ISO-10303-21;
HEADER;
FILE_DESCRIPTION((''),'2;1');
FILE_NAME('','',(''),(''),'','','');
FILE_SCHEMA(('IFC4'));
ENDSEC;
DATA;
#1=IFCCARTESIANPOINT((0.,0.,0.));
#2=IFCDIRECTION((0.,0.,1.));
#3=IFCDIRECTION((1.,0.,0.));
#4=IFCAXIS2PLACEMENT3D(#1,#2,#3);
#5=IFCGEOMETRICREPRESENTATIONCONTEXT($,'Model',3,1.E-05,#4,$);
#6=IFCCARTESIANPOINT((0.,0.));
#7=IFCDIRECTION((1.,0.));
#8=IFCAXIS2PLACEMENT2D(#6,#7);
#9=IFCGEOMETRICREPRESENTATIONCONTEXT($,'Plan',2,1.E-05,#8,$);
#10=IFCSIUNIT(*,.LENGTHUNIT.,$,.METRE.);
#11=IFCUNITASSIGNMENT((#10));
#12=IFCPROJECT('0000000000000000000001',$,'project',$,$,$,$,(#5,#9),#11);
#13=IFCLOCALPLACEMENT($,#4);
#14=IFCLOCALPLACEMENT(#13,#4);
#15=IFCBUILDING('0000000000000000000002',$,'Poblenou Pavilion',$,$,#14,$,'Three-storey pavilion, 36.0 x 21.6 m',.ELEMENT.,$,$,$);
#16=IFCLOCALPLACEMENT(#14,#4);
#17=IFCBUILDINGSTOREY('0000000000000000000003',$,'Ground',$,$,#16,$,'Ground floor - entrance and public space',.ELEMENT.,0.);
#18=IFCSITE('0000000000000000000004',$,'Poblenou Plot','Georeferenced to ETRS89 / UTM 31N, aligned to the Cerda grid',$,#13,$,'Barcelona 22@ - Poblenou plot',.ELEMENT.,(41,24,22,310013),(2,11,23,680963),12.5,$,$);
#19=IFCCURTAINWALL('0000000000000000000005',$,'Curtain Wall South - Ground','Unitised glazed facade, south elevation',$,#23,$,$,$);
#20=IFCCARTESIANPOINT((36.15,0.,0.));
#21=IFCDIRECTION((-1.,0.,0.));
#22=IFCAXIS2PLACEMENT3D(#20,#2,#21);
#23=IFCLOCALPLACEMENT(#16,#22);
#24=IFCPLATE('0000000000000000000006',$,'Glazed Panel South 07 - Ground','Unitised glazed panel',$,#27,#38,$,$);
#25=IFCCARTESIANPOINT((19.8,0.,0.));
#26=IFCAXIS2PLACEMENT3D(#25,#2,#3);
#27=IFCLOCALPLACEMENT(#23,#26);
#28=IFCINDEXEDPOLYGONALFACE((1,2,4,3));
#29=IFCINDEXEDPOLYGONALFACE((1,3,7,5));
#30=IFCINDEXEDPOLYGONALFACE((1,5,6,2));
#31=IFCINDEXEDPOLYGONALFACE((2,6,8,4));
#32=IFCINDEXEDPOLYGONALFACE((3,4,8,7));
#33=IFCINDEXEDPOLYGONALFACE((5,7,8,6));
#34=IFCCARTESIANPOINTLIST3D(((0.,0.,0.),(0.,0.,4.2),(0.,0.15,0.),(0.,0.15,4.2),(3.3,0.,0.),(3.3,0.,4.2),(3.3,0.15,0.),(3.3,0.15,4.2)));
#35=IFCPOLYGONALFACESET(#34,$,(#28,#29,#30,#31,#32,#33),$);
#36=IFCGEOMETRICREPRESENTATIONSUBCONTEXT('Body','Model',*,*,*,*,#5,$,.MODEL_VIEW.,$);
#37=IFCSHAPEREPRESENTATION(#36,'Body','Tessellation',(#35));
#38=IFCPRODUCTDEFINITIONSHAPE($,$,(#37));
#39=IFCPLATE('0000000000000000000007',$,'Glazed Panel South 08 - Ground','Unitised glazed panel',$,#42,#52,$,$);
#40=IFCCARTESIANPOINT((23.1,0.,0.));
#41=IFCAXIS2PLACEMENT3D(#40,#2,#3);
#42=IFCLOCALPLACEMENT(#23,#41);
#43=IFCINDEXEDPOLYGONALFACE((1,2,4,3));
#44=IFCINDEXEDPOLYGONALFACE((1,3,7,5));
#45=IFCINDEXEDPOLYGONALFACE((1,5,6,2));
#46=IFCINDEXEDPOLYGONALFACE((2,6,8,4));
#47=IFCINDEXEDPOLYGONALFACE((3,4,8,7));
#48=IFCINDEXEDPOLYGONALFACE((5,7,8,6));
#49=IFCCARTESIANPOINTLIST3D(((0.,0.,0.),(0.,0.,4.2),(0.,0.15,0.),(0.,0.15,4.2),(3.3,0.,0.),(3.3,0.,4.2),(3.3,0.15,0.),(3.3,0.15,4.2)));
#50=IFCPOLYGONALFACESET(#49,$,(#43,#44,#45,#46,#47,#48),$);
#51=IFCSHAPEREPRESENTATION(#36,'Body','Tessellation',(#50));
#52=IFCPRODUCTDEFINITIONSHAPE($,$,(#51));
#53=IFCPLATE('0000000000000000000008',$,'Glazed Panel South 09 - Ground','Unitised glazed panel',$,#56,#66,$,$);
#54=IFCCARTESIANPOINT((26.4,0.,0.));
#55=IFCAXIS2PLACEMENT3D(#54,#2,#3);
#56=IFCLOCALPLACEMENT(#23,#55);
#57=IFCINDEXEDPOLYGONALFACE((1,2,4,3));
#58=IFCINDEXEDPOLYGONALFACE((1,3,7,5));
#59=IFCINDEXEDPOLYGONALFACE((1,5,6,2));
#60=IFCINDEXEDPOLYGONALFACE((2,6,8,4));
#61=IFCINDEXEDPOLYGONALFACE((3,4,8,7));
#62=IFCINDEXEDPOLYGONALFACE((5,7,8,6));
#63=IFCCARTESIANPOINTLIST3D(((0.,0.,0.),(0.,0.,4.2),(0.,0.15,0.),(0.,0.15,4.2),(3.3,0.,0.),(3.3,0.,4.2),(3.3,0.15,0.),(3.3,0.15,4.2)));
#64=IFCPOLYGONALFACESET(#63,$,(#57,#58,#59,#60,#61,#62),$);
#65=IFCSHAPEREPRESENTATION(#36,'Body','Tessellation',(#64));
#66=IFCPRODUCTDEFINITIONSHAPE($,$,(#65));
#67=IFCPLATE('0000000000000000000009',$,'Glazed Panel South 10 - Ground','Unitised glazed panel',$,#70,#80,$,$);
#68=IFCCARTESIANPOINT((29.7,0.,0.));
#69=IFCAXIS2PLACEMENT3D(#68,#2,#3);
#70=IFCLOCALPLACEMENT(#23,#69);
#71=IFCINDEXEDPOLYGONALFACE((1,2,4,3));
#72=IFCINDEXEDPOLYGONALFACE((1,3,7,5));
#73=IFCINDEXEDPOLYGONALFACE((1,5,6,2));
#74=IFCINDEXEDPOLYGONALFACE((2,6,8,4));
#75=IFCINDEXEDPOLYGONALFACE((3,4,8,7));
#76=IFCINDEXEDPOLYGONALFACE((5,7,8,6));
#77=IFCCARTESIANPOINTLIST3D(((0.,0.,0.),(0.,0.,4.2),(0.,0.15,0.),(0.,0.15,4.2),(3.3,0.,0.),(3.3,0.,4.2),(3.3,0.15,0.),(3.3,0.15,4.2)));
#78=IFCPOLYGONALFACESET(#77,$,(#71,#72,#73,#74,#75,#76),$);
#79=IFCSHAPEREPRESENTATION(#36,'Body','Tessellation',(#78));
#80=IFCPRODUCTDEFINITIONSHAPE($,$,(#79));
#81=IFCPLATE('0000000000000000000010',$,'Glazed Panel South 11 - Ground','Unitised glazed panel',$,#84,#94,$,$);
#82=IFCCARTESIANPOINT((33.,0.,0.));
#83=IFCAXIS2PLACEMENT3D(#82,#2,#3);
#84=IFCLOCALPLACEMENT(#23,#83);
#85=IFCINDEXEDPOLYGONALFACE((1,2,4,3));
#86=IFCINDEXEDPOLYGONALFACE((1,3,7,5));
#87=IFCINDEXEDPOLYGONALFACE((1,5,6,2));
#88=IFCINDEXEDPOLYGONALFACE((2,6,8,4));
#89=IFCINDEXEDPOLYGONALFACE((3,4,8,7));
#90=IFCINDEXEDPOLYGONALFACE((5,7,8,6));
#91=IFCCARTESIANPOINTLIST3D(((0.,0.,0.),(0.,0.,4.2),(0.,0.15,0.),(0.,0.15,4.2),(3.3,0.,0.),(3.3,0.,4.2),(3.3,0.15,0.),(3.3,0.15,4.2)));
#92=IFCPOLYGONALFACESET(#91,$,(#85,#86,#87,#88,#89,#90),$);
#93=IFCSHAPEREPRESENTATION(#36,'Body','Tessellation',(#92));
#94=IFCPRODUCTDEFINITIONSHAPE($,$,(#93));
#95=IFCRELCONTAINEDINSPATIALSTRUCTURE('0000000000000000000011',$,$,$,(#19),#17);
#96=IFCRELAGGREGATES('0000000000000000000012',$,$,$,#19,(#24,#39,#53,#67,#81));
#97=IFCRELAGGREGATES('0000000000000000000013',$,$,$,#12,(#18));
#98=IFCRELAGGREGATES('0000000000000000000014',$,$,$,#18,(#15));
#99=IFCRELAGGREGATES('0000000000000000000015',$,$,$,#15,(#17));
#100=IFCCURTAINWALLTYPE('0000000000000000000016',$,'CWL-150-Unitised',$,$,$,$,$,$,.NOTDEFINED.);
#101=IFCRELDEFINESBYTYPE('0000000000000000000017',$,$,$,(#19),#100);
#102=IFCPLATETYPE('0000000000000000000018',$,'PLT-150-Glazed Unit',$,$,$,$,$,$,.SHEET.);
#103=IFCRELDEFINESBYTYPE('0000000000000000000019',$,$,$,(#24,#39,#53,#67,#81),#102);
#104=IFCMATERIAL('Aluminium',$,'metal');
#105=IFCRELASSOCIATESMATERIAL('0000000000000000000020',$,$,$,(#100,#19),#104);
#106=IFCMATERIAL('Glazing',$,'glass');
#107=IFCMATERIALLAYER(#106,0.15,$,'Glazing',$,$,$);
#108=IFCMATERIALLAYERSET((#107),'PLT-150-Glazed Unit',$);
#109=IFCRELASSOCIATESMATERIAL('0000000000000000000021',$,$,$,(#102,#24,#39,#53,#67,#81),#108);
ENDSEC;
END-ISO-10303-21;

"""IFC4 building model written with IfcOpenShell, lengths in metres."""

from ifc_helpers import new_model, si_unit, frame, origin_with_axes, origin_2d_with_axis, place, context, subcontext, project, spatial, line, indexed_curve, outline, extrude, material, layer, layer_set, layer_usage, type_object, element, aggregate, save


model = new_model("IFC4")

# Units and contexts
model_context = context("Model", 3, precision=1e-05, world=origin_with_axes())
plan_context = context("Plan", 2, precision=1e-05, world=origin_2d_with_axis())
body_context = subcontext(model_context, "Body", "Model", "MODEL_VIEW")
ifc_project = project(units=[si_unit("LENGTHUNIT", "METRE")], contexts=[model_context, plan_context])

# Site, building, storey
site_placement = place(None, origin_with_axes())
site = spatial("IfcSite", under=ifc_project, at=site_placement, Name="Poblenou Plot", Description="Georeferenced to ETRS89 / UTM 31N, aligned to the Cerda grid", LongName="Barcelona 22@ - Poblenou plot", CompositionType="ELEMENT", RefLatitude=(41, 24, 22, 310013), RefLongitude=(2, 11, 23, 680963), RefElevation=12.5)
building_placement = place(site_placement, origin_with_axes())
building = spatial("IfcBuilding", under=site, at=building_placement, Name="Poblenou Pavilion", LongName="Three-storey pavilion, 36.0 x 21.6 m", CompositionType="ELEMENT")
storey_placement = place(building_placement, origin_with_axes())
storey = spatial("IfcBuildingStorey", under=building, at=storey_placement, Name="Ground", LongName="Ground floor - entrance and public space", CompositionType="ELEMENT", Elevation=0.0)

# Curtain wall, plates
ifc_material_1 = material(Name="Aluminium", Category="metal")
curtain_wall_type = type_object("IfcCurtainWallType", Name="CWL-150-Unitised", PredefinedType="NOTDEFINED", material=ifc_material_1)
curtain_wall_1_placement = place(storey_placement, frame((36.15, 0.0, 0.0), z_axis=(0.0, 0.0, 1.0), x_axis=(-1.0, 0.0, 0.0)))
curtain_wall_1 = element("IfcCurtainWall", 1, at=curtain_wall_1_placement, inside=storey, type_object=curtain_wall_type, material=ifc_material_1, Name="Curtain Wall South - Ground", Description="Unitised glazed facade, south elevation")
ifc_material_2 = material(Name="Glazing", Category="glass")
ifc_layer_1 = layer(ifc_material_2, 0.15, Name="Glazing")
ifc_layer_set_1 = layer_set([ifc_layer_1], Name="PLT-150-Glazed Unit")
ifc_layer_usage_1 = layer_usage(ifc_layer_set_1, "AXIS2", "POSITIVE", 0.0)
plate_type = type_object("IfcPlateType", Name="PLT-150-Glazed Unit", PredefinedType="SHEET", material=ifc_layer_set_1)
plate_1_placement = place(curtain_wall_1_placement, frame((19.8, 0.0, 0.0), z_axis=(0.0, 0.0, 1.0), x_axis=(1.0, 0.0, 0.0)))
plate_1 = element("IfcPlate", 2, at=plate_1_placement, type_object=plate_type, material=ifc_layer_usage_1, Name="Glazed Panel South 07 - Ground", Description="Unitised glazed panel", context=body_context, shape_type="SweptSolid", body=[
    extrude(outline(indexed_curve([(0.0, 0.0), (3.3, 0.0), (3.3, 0.15), (0.0, 0.15)], segments=[line(1, 2, 3, 4, 1)])), origin_with_axes(), (0.0, 0.0, 1.0), 4.2),
])
ifc_layer_usage_2 = layer_usage(ifc_layer_set_1, "AXIS2", "POSITIVE", 0.0)
plate_2_placement = place(curtain_wall_1_placement, frame((23.1, 0.0, 0.0), z_axis=(0.0, 0.0, 1.0), x_axis=(1.0, 0.0, 0.0)))
plate_2 = element("IfcPlate", 3, at=plate_2_placement, type_object=plate_type, material=ifc_layer_usage_2, Name="Glazed Panel South 08 - Ground", Description="Unitised glazed panel", context=body_context, shape_type="SweptSolid", body=[
    extrude(outline(indexed_curve([(0.0, 0.0), (3.3, 0.0), (3.3, 0.15), (0.0, 0.15)], segments=[line(1, 2, 3, 4, 1)])), origin_with_axes(), (0.0, 0.0, 1.0), 4.2),
])
ifc_layer_usage_3 = layer_usage(ifc_layer_set_1, "AXIS2", "POSITIVE", 0.0)
plate_3_placement = place(curtain_wall_1_placement, frame((26.4, 0.0, 0.0), z_axis=(0.0, 0.0, 1.0), x_axis=(1.0, 0.0, 0.0)))
plate_3 = element("IfcPlate", 4, at=plate_3_placement, type_object=plate_type, material=ifc_layer_usage_3, Name="Glazed Panel South 09 - Ground", Description="Unitised glazed panel", context=body_context, shape_type="SweptSolid", body=[
    extrude(outline(indexed_curve([(0.0, 0.0), (3.3, 0.0), (3.3, 0.15), (0.0, 0.15)], segments=[line(1, 2, 3, 4, 1)])), origin_with_axes(), (0.0, 0.0, 1.0), 4.2),
])
ifc_layer_usage_4 = layer_usage(ifc_layer_set_1, "AXIS2", "POSITIVE", 0.0)
plate_4_placement = place(curtain_wall_1_placement, frame((29.7, 0.0, 0.0), z_axis=(0.0, 0.0, 1.0), x_axis=(1.0, 0.0, 0.0)))
plate_4 = element("IfcPlate", 5, at=plate_4_placement, type_object=plate_type, material=ifc_layer_usage_4, Name="Glazed Panel South 10 - Ground", Description="Unitised glazed panel", context=body_context, shape_type="SweptSolid", body=[
    extrude(outline(indexed_curve([(0.0, 0.0), (3.3, 0.0), (3.3, 0.15), (0.0, 0.15)], segments=[line(1, 2, 3, 4, 1)])), origin_with_axes(), (0.0, 0.0, 1.0), 4.2),
])
ifc_layer_usage_5 = layer_usage(ifc_layer_set_1, "AXIS2", "POSITIVE", 0.0)
plate_5_placement = place(curtain_wall_1_placement, frame((33.0, 0.0, 0.0), z_axis=(0.0, 0.0, 1.0), x_axis=(1.0, 0.0, 0.0)))
plate_5 = element("IfcPlate", 6, at=plate_5_placement, type_object=plate_type, material=ifc_layer_usage_5, Name="Glazed Panel South 11 - Ground", Description="Unitised glazed panel", context=body_context, shape_type="SweptSolid", body=[
    extrude(outline(indexed_curve([(0.0, 0.0), (3.3, 0.0), (3.3, 0.15), (0.0, 0.15)], segments=[line(1, 2, 3, 4, 1)])), origin_with_axes(), (0.0, 0.0, 1.0), 4.2),
])
aggregate(curtain_wall_1, [plate_1, plate_2, plate_3, plate_4, plate_5])

save(model, "model.ifc")
